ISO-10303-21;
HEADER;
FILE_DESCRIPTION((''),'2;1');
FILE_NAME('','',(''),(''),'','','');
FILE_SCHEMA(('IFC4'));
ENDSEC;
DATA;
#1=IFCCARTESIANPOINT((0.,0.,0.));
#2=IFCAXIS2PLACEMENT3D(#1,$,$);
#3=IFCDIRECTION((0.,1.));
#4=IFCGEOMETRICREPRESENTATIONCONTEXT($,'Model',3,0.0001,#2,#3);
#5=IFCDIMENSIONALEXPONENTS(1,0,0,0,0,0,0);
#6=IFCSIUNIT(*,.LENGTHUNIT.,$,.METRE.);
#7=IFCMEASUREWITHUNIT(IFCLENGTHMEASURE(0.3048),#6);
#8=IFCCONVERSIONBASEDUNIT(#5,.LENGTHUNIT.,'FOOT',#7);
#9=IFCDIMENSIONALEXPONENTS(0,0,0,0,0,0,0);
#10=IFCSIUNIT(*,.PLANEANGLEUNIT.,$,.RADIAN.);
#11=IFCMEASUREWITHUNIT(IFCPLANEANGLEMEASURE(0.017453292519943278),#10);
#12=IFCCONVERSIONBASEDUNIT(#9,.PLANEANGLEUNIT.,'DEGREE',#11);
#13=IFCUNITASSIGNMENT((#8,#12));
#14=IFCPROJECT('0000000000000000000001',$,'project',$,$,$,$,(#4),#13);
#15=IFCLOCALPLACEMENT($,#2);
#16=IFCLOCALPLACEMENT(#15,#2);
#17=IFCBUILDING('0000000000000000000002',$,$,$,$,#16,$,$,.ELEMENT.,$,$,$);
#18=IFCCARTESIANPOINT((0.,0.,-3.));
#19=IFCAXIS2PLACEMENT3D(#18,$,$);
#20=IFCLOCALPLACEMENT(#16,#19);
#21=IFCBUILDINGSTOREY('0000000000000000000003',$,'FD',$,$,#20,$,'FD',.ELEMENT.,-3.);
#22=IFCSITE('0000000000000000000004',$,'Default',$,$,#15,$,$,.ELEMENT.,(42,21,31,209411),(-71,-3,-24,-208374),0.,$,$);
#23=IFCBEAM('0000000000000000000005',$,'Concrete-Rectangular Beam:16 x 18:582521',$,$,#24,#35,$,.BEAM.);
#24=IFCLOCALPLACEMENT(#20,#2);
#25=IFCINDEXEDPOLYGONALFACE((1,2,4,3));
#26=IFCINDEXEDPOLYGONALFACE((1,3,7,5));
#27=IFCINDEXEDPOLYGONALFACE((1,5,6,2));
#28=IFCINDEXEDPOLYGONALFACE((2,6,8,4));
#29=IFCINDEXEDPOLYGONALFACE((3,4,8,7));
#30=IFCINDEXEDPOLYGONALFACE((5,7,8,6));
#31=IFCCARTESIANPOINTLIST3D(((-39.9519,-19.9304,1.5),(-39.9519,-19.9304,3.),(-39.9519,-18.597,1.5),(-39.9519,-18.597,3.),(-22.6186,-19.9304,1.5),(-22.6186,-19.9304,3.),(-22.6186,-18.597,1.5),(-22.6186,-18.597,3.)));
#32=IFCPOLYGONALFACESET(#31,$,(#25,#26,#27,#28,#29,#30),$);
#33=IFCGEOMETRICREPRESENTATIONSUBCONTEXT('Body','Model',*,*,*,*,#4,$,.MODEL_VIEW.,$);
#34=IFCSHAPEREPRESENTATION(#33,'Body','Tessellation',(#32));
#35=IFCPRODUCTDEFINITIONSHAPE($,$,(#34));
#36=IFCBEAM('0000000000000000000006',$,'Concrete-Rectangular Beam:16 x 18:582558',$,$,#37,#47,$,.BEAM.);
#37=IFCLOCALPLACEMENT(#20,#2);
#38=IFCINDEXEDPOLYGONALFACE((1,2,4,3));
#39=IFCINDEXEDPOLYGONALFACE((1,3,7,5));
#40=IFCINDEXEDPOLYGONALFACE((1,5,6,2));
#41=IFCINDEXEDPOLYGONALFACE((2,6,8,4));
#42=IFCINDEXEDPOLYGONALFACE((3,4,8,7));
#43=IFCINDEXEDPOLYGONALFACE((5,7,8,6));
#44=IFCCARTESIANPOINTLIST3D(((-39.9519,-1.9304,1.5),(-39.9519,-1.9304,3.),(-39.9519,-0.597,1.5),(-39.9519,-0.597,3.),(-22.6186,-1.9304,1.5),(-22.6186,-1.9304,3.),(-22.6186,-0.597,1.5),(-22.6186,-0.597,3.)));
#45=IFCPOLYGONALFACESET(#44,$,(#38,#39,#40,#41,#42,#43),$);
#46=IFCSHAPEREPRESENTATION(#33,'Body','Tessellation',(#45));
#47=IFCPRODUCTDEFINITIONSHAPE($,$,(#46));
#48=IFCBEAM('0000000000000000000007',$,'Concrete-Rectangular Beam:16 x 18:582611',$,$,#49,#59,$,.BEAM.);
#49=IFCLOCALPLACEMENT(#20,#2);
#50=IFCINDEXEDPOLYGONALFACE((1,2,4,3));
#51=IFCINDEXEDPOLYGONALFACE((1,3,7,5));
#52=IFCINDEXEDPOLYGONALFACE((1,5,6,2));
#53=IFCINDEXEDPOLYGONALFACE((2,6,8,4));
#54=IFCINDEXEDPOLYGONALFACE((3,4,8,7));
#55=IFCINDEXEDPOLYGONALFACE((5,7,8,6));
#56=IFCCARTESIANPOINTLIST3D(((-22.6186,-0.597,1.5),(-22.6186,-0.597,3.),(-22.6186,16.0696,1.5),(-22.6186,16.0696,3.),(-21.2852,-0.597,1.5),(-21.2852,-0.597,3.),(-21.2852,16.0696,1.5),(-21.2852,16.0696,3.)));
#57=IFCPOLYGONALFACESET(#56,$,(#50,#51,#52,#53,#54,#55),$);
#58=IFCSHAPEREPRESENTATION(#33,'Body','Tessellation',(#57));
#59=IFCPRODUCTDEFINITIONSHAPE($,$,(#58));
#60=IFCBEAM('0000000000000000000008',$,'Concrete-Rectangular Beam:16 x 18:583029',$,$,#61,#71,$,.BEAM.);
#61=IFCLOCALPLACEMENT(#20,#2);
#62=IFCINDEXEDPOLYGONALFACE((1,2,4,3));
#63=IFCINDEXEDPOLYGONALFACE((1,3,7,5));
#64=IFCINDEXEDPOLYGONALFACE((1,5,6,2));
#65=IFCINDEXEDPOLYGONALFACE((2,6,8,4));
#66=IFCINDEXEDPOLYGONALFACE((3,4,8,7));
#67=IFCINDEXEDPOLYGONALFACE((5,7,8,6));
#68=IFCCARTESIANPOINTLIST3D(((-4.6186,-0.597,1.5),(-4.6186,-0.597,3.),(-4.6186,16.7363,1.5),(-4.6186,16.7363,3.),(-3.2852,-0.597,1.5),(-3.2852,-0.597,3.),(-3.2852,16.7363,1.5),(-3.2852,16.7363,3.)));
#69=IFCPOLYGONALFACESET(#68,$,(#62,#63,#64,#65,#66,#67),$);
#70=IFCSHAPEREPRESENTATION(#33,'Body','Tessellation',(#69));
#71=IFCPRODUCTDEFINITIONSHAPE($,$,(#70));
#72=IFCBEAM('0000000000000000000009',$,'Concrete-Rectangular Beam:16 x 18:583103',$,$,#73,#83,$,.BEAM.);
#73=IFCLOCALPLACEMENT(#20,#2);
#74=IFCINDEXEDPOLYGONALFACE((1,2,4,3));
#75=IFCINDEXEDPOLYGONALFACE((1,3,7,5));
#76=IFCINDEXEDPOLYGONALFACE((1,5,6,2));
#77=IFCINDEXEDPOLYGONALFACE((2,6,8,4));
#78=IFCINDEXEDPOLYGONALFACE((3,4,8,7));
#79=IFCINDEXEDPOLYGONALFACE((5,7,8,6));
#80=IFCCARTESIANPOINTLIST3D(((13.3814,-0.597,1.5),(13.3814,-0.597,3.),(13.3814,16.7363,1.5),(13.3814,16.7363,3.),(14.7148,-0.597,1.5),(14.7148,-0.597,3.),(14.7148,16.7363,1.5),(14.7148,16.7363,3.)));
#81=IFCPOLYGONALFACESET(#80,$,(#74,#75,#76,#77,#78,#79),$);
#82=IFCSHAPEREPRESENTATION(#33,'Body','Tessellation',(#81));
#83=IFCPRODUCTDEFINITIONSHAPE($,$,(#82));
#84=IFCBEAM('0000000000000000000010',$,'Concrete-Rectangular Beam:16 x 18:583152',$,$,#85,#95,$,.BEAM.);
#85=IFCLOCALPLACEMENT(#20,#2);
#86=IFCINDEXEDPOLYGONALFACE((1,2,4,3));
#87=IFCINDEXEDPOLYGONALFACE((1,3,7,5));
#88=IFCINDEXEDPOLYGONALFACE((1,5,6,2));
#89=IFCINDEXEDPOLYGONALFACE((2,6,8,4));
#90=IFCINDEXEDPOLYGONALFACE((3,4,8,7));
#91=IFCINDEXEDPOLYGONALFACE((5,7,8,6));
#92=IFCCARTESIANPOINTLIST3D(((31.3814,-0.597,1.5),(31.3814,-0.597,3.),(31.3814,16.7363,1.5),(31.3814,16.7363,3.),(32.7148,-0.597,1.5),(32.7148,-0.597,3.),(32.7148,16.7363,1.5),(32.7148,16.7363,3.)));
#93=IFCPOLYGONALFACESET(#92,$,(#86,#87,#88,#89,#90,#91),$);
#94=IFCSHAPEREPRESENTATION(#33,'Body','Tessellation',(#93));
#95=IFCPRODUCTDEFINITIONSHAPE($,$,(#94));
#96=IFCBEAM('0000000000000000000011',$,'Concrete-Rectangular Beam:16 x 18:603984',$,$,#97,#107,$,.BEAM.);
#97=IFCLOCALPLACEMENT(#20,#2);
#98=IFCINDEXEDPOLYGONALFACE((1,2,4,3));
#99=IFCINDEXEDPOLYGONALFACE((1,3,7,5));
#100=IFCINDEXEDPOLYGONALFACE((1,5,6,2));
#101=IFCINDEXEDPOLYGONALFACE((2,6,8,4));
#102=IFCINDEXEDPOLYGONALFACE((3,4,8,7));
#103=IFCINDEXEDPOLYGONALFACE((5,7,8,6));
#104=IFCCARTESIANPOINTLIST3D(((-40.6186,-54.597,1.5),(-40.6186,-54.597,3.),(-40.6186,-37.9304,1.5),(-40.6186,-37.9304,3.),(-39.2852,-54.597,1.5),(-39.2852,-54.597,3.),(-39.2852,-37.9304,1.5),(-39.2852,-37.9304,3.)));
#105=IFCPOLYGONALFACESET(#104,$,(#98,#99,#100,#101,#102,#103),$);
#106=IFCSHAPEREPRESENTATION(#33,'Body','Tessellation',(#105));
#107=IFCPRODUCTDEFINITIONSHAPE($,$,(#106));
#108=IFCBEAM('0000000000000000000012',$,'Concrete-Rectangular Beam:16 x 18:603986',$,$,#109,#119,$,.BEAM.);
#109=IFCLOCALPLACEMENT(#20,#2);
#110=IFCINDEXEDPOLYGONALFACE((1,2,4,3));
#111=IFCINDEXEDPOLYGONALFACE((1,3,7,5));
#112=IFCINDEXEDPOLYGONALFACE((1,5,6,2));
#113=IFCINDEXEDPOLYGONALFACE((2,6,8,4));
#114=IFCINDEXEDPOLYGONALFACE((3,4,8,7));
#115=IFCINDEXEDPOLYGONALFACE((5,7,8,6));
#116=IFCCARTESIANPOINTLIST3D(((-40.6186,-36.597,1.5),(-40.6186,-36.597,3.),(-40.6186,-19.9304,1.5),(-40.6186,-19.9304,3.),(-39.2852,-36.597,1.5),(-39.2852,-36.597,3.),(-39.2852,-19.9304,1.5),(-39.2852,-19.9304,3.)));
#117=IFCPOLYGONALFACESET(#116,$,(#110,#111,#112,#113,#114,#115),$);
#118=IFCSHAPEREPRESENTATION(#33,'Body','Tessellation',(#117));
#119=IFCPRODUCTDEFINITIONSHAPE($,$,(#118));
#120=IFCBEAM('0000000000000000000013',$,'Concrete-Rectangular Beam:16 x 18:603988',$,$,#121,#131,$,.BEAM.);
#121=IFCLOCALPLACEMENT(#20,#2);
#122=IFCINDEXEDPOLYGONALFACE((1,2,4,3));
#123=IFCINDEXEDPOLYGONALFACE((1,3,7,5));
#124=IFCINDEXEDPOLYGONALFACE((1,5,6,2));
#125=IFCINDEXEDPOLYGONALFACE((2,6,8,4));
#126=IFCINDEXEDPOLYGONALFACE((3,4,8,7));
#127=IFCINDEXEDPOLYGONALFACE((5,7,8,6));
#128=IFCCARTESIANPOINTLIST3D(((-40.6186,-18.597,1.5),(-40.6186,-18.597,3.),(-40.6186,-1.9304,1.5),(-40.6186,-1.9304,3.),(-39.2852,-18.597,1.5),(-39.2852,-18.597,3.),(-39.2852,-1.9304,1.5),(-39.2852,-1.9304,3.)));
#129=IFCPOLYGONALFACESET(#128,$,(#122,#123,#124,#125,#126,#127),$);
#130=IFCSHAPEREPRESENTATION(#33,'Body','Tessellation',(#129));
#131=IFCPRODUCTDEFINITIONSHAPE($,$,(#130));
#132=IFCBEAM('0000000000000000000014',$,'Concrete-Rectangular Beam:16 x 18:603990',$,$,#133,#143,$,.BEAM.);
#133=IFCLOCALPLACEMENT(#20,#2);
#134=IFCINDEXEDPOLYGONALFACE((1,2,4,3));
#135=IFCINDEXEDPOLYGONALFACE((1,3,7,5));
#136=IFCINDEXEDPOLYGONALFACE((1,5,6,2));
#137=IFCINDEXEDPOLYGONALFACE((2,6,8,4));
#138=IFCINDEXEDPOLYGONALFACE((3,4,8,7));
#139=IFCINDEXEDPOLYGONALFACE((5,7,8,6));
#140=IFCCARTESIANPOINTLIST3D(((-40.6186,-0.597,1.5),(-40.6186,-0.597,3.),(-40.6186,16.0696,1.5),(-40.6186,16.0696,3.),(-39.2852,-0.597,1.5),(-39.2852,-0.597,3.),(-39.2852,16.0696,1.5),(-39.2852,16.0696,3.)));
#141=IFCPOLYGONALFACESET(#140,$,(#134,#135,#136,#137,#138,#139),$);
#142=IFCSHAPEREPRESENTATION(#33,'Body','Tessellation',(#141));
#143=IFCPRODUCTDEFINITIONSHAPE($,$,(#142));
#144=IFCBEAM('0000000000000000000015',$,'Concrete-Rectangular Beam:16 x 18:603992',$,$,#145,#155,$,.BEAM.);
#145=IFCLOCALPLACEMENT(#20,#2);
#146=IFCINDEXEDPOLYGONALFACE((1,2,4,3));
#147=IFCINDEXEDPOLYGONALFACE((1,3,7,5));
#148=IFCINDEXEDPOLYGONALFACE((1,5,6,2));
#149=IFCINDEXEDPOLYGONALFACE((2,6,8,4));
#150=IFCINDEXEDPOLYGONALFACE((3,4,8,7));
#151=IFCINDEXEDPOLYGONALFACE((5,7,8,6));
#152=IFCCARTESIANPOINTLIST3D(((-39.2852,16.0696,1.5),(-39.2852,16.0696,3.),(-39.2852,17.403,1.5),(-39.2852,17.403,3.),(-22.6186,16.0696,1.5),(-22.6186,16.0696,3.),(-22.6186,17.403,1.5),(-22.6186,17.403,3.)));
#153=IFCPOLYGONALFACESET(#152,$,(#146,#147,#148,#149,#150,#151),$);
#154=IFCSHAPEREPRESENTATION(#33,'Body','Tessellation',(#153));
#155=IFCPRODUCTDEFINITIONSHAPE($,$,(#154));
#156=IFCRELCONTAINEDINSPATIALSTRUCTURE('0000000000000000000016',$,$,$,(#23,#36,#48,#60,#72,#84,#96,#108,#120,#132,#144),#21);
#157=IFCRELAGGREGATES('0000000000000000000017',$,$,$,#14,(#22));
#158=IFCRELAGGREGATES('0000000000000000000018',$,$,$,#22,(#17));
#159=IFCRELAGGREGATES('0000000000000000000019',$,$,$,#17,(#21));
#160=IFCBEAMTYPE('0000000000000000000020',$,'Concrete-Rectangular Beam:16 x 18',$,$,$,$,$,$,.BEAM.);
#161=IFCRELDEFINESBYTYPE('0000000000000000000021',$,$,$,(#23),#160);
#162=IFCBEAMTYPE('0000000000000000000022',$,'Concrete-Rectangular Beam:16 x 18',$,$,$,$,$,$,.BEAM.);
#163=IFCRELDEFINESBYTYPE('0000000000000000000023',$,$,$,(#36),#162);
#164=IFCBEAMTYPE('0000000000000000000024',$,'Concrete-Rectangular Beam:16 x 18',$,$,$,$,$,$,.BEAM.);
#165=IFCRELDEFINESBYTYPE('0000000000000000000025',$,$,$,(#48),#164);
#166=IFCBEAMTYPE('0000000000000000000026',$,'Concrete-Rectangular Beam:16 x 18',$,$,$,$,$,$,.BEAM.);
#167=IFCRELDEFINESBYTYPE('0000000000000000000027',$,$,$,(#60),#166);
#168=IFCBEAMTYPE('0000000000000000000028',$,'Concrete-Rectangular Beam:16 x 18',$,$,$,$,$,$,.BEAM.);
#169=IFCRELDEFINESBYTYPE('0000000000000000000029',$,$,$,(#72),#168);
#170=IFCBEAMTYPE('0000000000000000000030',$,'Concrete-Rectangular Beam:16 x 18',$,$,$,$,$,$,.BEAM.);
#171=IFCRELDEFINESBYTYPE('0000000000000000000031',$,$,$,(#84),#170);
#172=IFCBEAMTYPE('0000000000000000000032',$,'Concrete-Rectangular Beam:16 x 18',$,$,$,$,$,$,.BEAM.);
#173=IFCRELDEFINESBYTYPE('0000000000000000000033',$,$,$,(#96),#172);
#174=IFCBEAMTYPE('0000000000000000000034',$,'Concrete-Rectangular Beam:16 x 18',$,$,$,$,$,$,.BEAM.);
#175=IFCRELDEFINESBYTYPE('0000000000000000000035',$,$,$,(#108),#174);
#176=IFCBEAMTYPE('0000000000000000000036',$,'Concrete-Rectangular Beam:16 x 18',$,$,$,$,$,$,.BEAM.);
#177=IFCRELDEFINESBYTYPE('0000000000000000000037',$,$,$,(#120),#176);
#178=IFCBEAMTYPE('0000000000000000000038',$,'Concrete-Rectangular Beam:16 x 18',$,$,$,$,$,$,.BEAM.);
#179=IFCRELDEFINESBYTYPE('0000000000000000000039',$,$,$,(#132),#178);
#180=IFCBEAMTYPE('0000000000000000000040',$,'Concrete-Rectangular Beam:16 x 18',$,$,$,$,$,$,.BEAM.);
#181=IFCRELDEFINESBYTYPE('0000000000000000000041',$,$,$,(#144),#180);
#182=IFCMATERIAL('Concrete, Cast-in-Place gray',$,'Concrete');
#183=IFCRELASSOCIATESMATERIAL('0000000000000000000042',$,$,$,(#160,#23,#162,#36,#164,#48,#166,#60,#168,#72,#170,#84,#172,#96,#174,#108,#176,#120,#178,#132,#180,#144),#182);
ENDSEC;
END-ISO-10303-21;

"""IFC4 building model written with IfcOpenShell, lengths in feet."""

from ifc_helpers import new_model, entity, si_unit, converted_unit, direction, frame, origin, place, context, subcontext, project, spatial, indexed_curve, outline, extrude, source, transform, mapped, material, type_object, type_shapes, element, save


model = new_model("IFC4")

# Units and contexts
model_context = context("Model", 3, precision=0.0001, world=origin(), true_north=direction((0.0, 1.0)))
body_context = subcontext(model_context, "Body", "Model", "MODEL_VIEW")
ifc_project = project(units=[converted_unit("LENGTHUNIT", "FOOT", entity("IfcLengthMeasure", 0.3048), si_unit("LENGTHUNIT", "METRE"), dimensions=[1, 0, 0, 0, 0, 0, 0]), converted_unit("PLANEANGLEUNIT", "DEGREE", entity("IfcPlaneAngleMeasure", 0.017453292519943278), si_unit("PLANEANGLEUNIT", "RADIAN"), dimensions=[0, 0, 0, 0, 0, 0, 0])], contexts=[model_context])

# Site, building, storey
site_placement = place(None, origin())
site = spatial("IfcSite", under=ifc_project, at=site_placement, Name="Default", CompositionType="ELEMENT", RefLatitude=(42, 21, 31, 209411), RefLongitude=(-71, -3, -24, -208374), RefElevation=0.0)
building_placement = place(site_placement, origin())
building = spatial("IfcBuilding", under=site, at=building_placement, CompositionType="ELEMENT")
storey_placement = place(building_placement, frame((0.0, 0.0, -3.0)))
storey = spatial("IfcBuildingStorey", under=building, at=storey_placement, Name="FD", LongName="FD", CompositionType="ELEMENT", Elevation=-3.0)

# Shared definitions
ifc_material = material(Name="Concrete, Cast-in-Place gray", Category="Concrete")

# Beams
beam_type_1 = type_object("IfcBeamType", Name="Concrete-Rectangular Beam:16 x 18", PredefinedType="BEAM", material=ifc_material)
shared_shape_1 = source(origin(), body_context, "Body", "SweptSolid", [
    extrude(outline(indexed_curve([(-0.75, -0.6667), (0.75, -0.6667), (0.75, 0.6667), (-0.75, 0.6667), (-0.75, -0.6667)], self_intersect=False)), frame((-39.9519, -19.2637, -0.75), z_axis=(1.0, 0.0, 0.0), x_axis=(0.0, 0.0, -1.0)), (0.0, 0.0, 1.0), 17.3333),
])
type_shapes(beam_type_1, [shared_shape_1])
beam_1_placement = place(storey_placement, frame((0.0, 0.0, 3.0)))
element("IfcBeam", 1, at=beam_1_placement, inside=storey, type_object=beam_type_1, material=ifc_material, Name="Concrete-Rectangular Beam:16 x 18:582521", PredefinedType="BEAM", context=body_context, shape_type="MappedRepresentation", body=[
    mapped(shared_shape_1, transform((0.0, 0.0, 0.0), scale=1.0)),
])
beam_type_2 = type_object("IfcBeamType", Name="Concrete-Rectangular Beam:16 x 18", PredefinedType="BEAM", material=ifc_material)
shared_shape_2 = source(origin(), body_context, "Body", "SweptSolid", [
    extrude(outline(indexed_curve([(-0.75, -0.6667), (0.75, -0.6667), (0.75, 0.6667), (-0.75, 0.6667), (-0.75, -0.6667)], self_intersect=False)), frame((-39.9519, -1.2637, -0.75), z_axis=(1.0, 0.0, 0.0), x_axis=(0.0, 0.0, -1.0)), (0.0, 0.0, 1.0), 17.3333),
])
type_shapes(beam_type_2, [shared_shape_2])
beam_2_placement = place(storey_placement, frame((0.0, 0.0, 3.0)))
element("IfcBeam", 2, at=beam_2_placement, inside=storey, type_object=beam_type_2, material=ifc_material, Name="Concrete-Rectangular Beam:16 x 18:582558", PredefinedType="BEAM", context=body_context, shape_type="MappedRepresentation", body=[
    mapped(shared_shape_2, transform((0.0, 0.0, 0.0), scale=1.0)),
])
beam_type_3 = type_object("IfcBeamType", Name="Concrete-Rectangular Beam:16 x 18", PredefinedType="BEAM", material=ifc_material)
shared_shape_3 = source(origin(), body_context, "Body", "SweptSolid", [
    extrude(outline(indexed_curve([(-0.6667, -0.75), (0.6667, -0.75), (0.6667, 0.75), (-0.6667, 0.75), (-0.6667, -0.75)], self_intersect=False)), frame((-21.9519, -0.597, -0.75), z_axis=(0.0, 1.0, 0.0), x_axis=(-1.0, 0.0, 0.0)), (0.0, 0.0, 1.0), 16.6667),
])
type_shapes(beam_type_3, [shared_shape_3])
beam_3_placement = place(storey_placement, frame((0.0, 0.0, 3.0)))
element("IfcBeam", 3, at=beam_3_placement, inside=storey, type_object=beam_type_3, material=ifc_material, Name="Concrete-Rectangular Beam:16 x 18:582611", PredefinedType="BEAM", context=body_context, shape_type="MappedRepresentation", body=[
    mapped(shared_shape_3, transform((0.0, 0.0, 0.0), scale=1.0)),
])
beam_type_4 = type_object("IfcBeamType", Name="Concrete-Rectangular Beam:16 x 18", PredefinedType="BEAM", material=ifc_material)
shared_shape_4 = source(origin(), body_context, "Body", "SweptSolid", [
    extrude(outline(indexed_curve([(-0.6667, -0.75), (0.6667, -0.75), (0.6667, 0.75), (-0.6667, 0.75), (-0.6667, -0.75)], self_intersect=False)), frame((-3.9519, -0.597, -0.75), z_axis=(0.0, 1.0, 0.0), x_axis=(-1.0, 0.0, 0.0)), (0.0, 0.0, 1.0), 17.3333),
])
type_shapes(beam_type_4, [shared_shape_4])
beam_4_placement = place(storey_placement, frame((0.0, 0.0, 3.0)))
element("IfcBeam", 4, at=beam_4_placement, inside=storey, type_object=beam_type_4, material=ifc_material, Name="Concrete-Rectangular Beam:16 x 18:583029", PredefinedType="BEAM", context=body_context, shape_type="MappedRepresentation", body=[
    mapped(shared_shape_4, transform((0.0, 0.0, 0.0), scale=1.0)),
])
beam_type_5 = type_object("IfcBeamType", Name="Concrete-Rectangular Beam:16 x 18", PredefinedType="BEAM", material=ifc_material)
shared_shape_5 = source(origin(), body_context, "Body", "SweptSolid", [
    extrude(outline(indexed_curve([(-0.6667, -0.75), (0.6667, -0.75), (0.6667, 0.75), (-0.6667, 0.75), (-0.6667, -0.75)], self_intersect=False)), frame((14.0481, -0.597, -0.75), z_axis=(0.0, 1.0, 0.0), x_axis=(-1.0, 0.0, 0.0)), (0.0, 0.0, 1.0), 17.3333),
])
type_shapes(beam_type_5, [shared_shape_5])
beam_5_placement = place(storey_placement, frame((0.0, 0.0, 3.0)))
element("IfcBeam", 5, at=beam_5_placement, inside=storey, type_object=beam_type_5, material=ifc_material, Name="Concrete-Rectangular Beam:16 x 18:583103", PredefinedType="BEAM", context=body_context, shape_type="MappedRepresentation", body=[
    mapped(shared_shape_5, transform((0.0, 0.0, 0.0), scale=1.0)),
])
beam_type_6 = type_object("IfcBeamType", Name="Concrete-Rectangular Beam:16 x 18", PredefinedType="BEAM", material=ifc_material)
shared_shape_6 = source(origin(), body_context, "Body", "SweptSolid", [
    extrude(outline(indexed_curve([(-0.6667, -0.75), (0.6667, -0.75), (0.6667, 0.75), (-0.6667, 0.75), (-0.6667, -0.75)], self_intersect=False)), frame((32.0481, -0.597, -0.75), z_axis=(0.0, 1.0, 0.0), x_axis=(-1.0, 0.0, 0.0)), (0.0, 0.0, 1.0), 17.3333),
])
type_shapes(beam_type_6, [shared_shape_6])
beam_6_placement = place(storey_placement, frame((0.0, 0.0, 3.0)))
element("IfcBeam", 6, at=beam_6_placement, inside=storey, type_object=beam_type_6, material=ifc_material, Name="Concrete-Rectangular Beam:16 x 18:583152", PredefinedType="BEAM", context=body_context, shape_type="MappedRepresentation", body=[
    mapped(shared_shape_6, transform((0.0, 0.0, 0.0), scale=1.0)),
])
beam_type_7 = type_object("IfcBeamType", Name="Concrete-Rectangular Beam:16 x 18", PredefinedType="BEAM", material=ifc_material)
shared_shape_7 = source(origin(), body_context, "Body", "SweptSolid", [
    extrude(outline(indexed_curve([(-0.6667, -0.75), (0.6667, -0.75), (0.6667, 0.75), (-0.6667, 0.75), (-0.6667, -0.75)], self_intersect=False)), frame((-39.9519, -54.597, -0.75), z_axis=(0.0, 1.0, 0.0), x_axis=(-1.0, 0.0, 0.0)), (0.0, 0.0, 1.0), 16.6667),
])
type_shapes(beam_type_7, [shared_shape_7])
beam_7_placement = place(storey_placement, frame((0.0, 0.0, 3.0)))
element("IfcBeam", 7, at=beam_7_placement, inside=storey, type_object=beam_type_7, material=ifc_material, Name="Concrete-Rectangular Beam:16 x 18:603984", PredefinedType="BEAM", context=body_context, shape_type="MappedRepresentation", body=[
    mapped(shared_shape_7, transform((0.0, 0.0, 0.0), scale=1.0)),
])
beam_type_8 = type_object("IfcBeamType", Name="Concrete-Rectangular Beam:16 x 18", PredefinedType="BEAM", material=ifc_material)
shared_shape_8 = source(origin(), body_context, "Body", "SweptSolid", [
    extrude(outline(indexed_curve([(-0.6667, -0.75), (0.6667, -0.75), (0.6667, 0.75), (-0.6667, 0.75), (-0.6667, -0.75)], self_intersect=False)), frame((-39.9519, -36.597, -0.75), z_axis=(0.0, 1.0, 0.0), x_axis=(-1.0, 0.0, 0.0)), (0.0, 0.0, 1.0), 16.6667),
])
type_shapes(beam_type_8, [shared_shape_8])
beam_8_placement = place(storey_placement, frame((0.0, 0.0, 3.0)))
element("IfcBeam", 8, at=beam_8_placement, inside=storey, type_object=beam_type_8, material=ifc_material, Name="Concrete-Rectangular Beam:16 x 18:603986", PredefinedType="BEAM", context=body_context, shape_type="MappedRepresentation", body=[
    mapped(shared_shape_8, transform((0.0, 0.0, 0.0), scale=1.0)),
])
beam_type_9 = type_object("IfcBeamType", Name="Concrete-Rectangular Beam:16 x 18", PredefinedType="BEAM", material=ifc_material)
shared_shape_9 = source(origin(), body_context, "Body", "SweptSolid", [
    extrude(outline(indexed_curve([(-0.6667, -0.75), (0.6667, -0.75), (0.6667, 0.75), (-0.6667, 0.75), (-0.6667, -0.75)], self_intersect=False)), frame((-39.9519, -18.597, -0.75), z_axis=(0.0, 1.0, 0.0), x_axis=(-1.0, 0.0, 0.0)), (0.0, 0.0, 1.0), 16.6667),
])
type_shapes(beam_type_9, [shared_shape_9])
beam_9_placement = place(storey_placement, frame((0.0, 0.0, 3.0)))
element("IfcBeam", 9, at=beam_9_placement, inside=storey, type_object=beam_type_9, material=ifc_material, Name="Concrete-Rectangular Beam:16 x 18:603988", PredefinedType="BEAM", context=body_context, shape_type="MappedRepresentation", body=[
    mapped(shared_shape_9, transform((0.0, 0.0, 0.0), scale=1.0)),
])
beam_type_10 = type_object("IfcBeamType", Name="Concrete-Rectangular Beam:16 x 18", PredefinedType="BEAM", material=ifc_material)
shared_shape_10 = source(origin(), body_context, "Body", "SweptSolid", [
    extrude(outline(indexed_curve([(-0.6667, -0.75), (0.6667, -0.75), (0.6667, 0.75), (-0.6667, 0.75), (-0.6667, -0.75)], self_intersect=False)), frame((-39.9519, -0.597, -0.75), z_axis=(0.0, 1.0, 0.0), x_axis=(-1.0, 0.0, 0.0)), (0.0, 0.0, 1.0), 16.6667),
])
type_shapes(beam_type_10, [shared_shape_10])
beam_10_placement = place(storey_placement, frame((0.0, 0.0, 3.0)))
element("IfcBeam", 10, at=beam_10_placement, inside=storey, type_object=beam_type_10, material=ifc_material, Name="Concrete-Rectangular Beam:16 x 18:603990", PredefinedType="BEAM", context=body_context, shape_type="MappedRepresentation", body=[
    mapped(shared_shape_10, transform((0.0, 0.0, 0.0), scale=1.0)),
])
beam_type_11 = type_object("IfcBeamType", Name="Concrete-Rectangular Beam:16 x 18", PredefinedType="BEAM", material=ifc_material)
shared_shape_11 = source(origin(), body_context, "Body", "SweptSolid", [
    extrude(outline(indexed_curve([(-0.75, -0.6667), (0.75, -0.6667), (0.75, 0.6667), (-0.75, 0.6667), (-0.75, -0.6667)], self_intersect=False)), frame((-39.2852, 16.7363, -0.75), z_axis=(1.0, 0.0, 0.0), x_axis=(0.0, 0.0, -1.0)), (0.0, 0.0, 1.0), 16.6667),
])
type_shapes(beam_type_11, [shared_shape_11])
beam_11_placement = place(storey_placement, frame((0.0, 0.0, 3.0)))
element("IfcBeam", 11, at=beam_11_placement, inside=storey, type_object=beam_type_11, material=ifc_material, Name="Concrete-Rectangular Beam:16 x 18:603992", PredefinedType="BEAM", context=body_context, shape_type="MappedRepresentation", body=[
    mapped(shared_shape_11, transform((0.0, 0.0, 0.0), scale=1.0)),
])

save(model, "model.ifc")
